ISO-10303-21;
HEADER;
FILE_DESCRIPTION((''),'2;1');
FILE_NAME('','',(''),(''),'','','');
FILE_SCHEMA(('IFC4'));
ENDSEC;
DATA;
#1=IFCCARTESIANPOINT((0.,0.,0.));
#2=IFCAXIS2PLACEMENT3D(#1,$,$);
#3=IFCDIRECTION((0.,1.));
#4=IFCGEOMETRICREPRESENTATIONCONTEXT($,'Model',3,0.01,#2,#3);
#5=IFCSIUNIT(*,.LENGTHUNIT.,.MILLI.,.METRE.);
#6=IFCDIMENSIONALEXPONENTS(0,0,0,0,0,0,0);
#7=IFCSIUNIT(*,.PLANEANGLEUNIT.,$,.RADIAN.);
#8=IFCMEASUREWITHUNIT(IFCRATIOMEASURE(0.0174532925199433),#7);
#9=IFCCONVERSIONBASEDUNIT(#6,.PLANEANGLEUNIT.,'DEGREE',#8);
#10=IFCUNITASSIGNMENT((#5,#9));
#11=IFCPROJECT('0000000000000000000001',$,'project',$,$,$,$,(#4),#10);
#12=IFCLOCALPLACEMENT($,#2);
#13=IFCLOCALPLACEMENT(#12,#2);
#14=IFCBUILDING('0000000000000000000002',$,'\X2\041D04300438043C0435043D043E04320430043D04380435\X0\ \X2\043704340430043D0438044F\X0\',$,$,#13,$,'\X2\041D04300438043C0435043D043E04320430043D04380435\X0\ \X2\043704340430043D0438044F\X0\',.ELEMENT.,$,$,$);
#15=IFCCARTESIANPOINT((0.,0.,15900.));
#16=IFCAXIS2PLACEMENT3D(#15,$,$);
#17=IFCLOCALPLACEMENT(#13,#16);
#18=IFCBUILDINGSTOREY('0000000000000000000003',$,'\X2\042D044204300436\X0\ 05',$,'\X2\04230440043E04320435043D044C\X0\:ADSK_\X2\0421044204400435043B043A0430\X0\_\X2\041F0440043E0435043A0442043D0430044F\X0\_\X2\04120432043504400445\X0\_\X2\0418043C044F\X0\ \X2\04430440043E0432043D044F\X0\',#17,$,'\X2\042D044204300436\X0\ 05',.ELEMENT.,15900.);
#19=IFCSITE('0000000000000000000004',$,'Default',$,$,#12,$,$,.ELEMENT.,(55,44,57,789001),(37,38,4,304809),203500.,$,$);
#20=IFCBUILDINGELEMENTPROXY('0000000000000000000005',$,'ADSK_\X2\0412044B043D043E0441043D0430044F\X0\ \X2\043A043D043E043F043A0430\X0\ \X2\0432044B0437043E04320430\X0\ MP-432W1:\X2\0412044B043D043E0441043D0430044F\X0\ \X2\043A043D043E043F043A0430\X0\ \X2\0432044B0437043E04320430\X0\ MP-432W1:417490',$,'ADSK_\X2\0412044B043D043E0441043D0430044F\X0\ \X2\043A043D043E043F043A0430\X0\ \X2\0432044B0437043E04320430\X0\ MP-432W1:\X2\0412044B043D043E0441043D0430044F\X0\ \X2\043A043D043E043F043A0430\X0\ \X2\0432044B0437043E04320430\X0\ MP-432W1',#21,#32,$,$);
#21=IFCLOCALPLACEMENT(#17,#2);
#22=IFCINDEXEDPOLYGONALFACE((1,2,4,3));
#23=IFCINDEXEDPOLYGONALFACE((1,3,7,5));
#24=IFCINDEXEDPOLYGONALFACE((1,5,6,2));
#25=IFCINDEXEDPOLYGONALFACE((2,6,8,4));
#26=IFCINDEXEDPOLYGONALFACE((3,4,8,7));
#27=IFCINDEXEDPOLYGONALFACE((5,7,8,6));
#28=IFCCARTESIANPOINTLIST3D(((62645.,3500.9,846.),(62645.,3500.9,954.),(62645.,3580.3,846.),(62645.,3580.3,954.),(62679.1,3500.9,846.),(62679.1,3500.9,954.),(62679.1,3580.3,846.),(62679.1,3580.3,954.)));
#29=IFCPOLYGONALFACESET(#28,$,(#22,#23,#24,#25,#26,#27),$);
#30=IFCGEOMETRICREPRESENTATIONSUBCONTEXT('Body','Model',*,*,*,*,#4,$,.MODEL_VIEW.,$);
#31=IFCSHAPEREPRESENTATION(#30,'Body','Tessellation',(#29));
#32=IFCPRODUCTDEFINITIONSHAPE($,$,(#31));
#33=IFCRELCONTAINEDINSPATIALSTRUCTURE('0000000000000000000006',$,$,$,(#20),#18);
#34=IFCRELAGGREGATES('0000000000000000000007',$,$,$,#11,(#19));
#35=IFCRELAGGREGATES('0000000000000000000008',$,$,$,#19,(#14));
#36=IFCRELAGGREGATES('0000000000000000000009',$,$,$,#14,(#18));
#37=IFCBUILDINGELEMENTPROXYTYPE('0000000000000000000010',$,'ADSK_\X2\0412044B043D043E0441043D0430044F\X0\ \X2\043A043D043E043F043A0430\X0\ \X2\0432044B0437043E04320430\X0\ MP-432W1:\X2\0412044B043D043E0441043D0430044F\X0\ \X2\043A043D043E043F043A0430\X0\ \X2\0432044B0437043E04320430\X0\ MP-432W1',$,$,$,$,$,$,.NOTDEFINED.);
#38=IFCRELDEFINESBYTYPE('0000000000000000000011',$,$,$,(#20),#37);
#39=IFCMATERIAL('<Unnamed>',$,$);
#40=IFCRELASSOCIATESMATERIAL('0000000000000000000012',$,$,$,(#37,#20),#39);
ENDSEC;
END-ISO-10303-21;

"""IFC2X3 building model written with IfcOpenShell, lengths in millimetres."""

from ifc_helpers import new_model, entity, si_unit, converted_unit, direction, frame, origin, origin_2d_with_axis, place, context, subcontext, project, spatial, rectangle, extrude, source, transform, mapped, material, type_object, type_shapes, element, save


model = new_model("IFC2X3")

# Units and contexts
model_context = context("Model", 3, precision=0.01, world=origin(), true_north=direction((0.0, 1.0)))
body_context = subcontext(model_context, "Body", "Model", "MODEL_VIEW")
ifc_project = project(units=[si_unit("LENGTHUNIT", "METRE", prefix="MILLI"), converted_unit("PLANEANGLEUNIT", "DEGREE", entity("IfcRatioMeasure", 0.0174532925199433), si_unit("PLANEANGLEUNIT", "RADIAN"), dimensions=[0, 0, 0, 0, 0, 0, 0])], contexts=[model_context])

# Site, building, storey
site_placement = place(None, origin())
site = spatial("IfcSite", under=ifc_project, at=site_placement, Name="Default", CompositionType="ELEMENT", RefLatitude=(55, 44, 57, 789001), RefLongitude=(37, 38, 4, 304809), RefElevation=203500.0)
building_placement = place(site_placement, origin())
building = spatial("IfcBuilding", under=site, at=building_placement, Name="Наименование здания", LongName="Наименование здания", CompositionType="ELEMENT")
storey_placement = place(building_placement, frame((0.0, 0.0, 15900.0)))
storey = spatial("IfcBuildingStorey", under=building, at=storey_placement, Name="Этаж 05", ObjectType="Уровень:ADSK_Стрелка_Проектная_Вверх_Имя уровня", LongName="Этаж 05", CompositionType="ELEMENT", Elevation=15900.0)

# Building element proxy
ifc_material = material(Name="<Unnamed>")
building_element_proxy_type_1 = type_object("IfcBuildingElementProxyType", Name="ADSK_Выносная кнопка вызова MP-432W1:Выносная кнопка вызова MP-432W1", PredefinedType="NOTDEFINED", material=ifc_material)
shared_shape_1 = source(origin(), body_context, "Body", "SweptSolid", [
    extrude(rectangle(XDim=79.5, YDim=34.1, at=origin_2d_with_axis()), frame((0.0, 15.0, -54.0), z_axis=(0.0, 0.0, 1.0), x_axis=(-1.0, 0.0, 0.0)), (0.0, 0.0, 1.0), 108.0),
])
type_shapes(building_element_proxy_type_1, [shared_shape_1])
for number, where, z_axis, x_axis, name in (
    (1, (62677.0, 3540.6, 900.0), (0.0, 0.0, 1.0), (0.0, 1.0, 0.0), "ADSK_Выносная кнопка вызова MP-432W1:Выносная кнопка вызова MP-432W1:417490"),
):
    element("IfcBuildingElementProxy", number, at=place(storey_placement, frame(where, z_axis=z_axis, x_axis=x_axis)), inside=storey, type_object=building_element_proxy_type_1, material=ifc_material, Name=name, ObjectType="ADSK_Выносная кнопка вызова MP-432W1:Выносная кнопка вызова MP-432W1", context=body_context, shape_type="MappedRepresentation", body=[
        mapped(shared_shape_1, transform((0.0, 0.0, 0.0), scale=1.0)),
    ])

save(model, "model.ifc")
